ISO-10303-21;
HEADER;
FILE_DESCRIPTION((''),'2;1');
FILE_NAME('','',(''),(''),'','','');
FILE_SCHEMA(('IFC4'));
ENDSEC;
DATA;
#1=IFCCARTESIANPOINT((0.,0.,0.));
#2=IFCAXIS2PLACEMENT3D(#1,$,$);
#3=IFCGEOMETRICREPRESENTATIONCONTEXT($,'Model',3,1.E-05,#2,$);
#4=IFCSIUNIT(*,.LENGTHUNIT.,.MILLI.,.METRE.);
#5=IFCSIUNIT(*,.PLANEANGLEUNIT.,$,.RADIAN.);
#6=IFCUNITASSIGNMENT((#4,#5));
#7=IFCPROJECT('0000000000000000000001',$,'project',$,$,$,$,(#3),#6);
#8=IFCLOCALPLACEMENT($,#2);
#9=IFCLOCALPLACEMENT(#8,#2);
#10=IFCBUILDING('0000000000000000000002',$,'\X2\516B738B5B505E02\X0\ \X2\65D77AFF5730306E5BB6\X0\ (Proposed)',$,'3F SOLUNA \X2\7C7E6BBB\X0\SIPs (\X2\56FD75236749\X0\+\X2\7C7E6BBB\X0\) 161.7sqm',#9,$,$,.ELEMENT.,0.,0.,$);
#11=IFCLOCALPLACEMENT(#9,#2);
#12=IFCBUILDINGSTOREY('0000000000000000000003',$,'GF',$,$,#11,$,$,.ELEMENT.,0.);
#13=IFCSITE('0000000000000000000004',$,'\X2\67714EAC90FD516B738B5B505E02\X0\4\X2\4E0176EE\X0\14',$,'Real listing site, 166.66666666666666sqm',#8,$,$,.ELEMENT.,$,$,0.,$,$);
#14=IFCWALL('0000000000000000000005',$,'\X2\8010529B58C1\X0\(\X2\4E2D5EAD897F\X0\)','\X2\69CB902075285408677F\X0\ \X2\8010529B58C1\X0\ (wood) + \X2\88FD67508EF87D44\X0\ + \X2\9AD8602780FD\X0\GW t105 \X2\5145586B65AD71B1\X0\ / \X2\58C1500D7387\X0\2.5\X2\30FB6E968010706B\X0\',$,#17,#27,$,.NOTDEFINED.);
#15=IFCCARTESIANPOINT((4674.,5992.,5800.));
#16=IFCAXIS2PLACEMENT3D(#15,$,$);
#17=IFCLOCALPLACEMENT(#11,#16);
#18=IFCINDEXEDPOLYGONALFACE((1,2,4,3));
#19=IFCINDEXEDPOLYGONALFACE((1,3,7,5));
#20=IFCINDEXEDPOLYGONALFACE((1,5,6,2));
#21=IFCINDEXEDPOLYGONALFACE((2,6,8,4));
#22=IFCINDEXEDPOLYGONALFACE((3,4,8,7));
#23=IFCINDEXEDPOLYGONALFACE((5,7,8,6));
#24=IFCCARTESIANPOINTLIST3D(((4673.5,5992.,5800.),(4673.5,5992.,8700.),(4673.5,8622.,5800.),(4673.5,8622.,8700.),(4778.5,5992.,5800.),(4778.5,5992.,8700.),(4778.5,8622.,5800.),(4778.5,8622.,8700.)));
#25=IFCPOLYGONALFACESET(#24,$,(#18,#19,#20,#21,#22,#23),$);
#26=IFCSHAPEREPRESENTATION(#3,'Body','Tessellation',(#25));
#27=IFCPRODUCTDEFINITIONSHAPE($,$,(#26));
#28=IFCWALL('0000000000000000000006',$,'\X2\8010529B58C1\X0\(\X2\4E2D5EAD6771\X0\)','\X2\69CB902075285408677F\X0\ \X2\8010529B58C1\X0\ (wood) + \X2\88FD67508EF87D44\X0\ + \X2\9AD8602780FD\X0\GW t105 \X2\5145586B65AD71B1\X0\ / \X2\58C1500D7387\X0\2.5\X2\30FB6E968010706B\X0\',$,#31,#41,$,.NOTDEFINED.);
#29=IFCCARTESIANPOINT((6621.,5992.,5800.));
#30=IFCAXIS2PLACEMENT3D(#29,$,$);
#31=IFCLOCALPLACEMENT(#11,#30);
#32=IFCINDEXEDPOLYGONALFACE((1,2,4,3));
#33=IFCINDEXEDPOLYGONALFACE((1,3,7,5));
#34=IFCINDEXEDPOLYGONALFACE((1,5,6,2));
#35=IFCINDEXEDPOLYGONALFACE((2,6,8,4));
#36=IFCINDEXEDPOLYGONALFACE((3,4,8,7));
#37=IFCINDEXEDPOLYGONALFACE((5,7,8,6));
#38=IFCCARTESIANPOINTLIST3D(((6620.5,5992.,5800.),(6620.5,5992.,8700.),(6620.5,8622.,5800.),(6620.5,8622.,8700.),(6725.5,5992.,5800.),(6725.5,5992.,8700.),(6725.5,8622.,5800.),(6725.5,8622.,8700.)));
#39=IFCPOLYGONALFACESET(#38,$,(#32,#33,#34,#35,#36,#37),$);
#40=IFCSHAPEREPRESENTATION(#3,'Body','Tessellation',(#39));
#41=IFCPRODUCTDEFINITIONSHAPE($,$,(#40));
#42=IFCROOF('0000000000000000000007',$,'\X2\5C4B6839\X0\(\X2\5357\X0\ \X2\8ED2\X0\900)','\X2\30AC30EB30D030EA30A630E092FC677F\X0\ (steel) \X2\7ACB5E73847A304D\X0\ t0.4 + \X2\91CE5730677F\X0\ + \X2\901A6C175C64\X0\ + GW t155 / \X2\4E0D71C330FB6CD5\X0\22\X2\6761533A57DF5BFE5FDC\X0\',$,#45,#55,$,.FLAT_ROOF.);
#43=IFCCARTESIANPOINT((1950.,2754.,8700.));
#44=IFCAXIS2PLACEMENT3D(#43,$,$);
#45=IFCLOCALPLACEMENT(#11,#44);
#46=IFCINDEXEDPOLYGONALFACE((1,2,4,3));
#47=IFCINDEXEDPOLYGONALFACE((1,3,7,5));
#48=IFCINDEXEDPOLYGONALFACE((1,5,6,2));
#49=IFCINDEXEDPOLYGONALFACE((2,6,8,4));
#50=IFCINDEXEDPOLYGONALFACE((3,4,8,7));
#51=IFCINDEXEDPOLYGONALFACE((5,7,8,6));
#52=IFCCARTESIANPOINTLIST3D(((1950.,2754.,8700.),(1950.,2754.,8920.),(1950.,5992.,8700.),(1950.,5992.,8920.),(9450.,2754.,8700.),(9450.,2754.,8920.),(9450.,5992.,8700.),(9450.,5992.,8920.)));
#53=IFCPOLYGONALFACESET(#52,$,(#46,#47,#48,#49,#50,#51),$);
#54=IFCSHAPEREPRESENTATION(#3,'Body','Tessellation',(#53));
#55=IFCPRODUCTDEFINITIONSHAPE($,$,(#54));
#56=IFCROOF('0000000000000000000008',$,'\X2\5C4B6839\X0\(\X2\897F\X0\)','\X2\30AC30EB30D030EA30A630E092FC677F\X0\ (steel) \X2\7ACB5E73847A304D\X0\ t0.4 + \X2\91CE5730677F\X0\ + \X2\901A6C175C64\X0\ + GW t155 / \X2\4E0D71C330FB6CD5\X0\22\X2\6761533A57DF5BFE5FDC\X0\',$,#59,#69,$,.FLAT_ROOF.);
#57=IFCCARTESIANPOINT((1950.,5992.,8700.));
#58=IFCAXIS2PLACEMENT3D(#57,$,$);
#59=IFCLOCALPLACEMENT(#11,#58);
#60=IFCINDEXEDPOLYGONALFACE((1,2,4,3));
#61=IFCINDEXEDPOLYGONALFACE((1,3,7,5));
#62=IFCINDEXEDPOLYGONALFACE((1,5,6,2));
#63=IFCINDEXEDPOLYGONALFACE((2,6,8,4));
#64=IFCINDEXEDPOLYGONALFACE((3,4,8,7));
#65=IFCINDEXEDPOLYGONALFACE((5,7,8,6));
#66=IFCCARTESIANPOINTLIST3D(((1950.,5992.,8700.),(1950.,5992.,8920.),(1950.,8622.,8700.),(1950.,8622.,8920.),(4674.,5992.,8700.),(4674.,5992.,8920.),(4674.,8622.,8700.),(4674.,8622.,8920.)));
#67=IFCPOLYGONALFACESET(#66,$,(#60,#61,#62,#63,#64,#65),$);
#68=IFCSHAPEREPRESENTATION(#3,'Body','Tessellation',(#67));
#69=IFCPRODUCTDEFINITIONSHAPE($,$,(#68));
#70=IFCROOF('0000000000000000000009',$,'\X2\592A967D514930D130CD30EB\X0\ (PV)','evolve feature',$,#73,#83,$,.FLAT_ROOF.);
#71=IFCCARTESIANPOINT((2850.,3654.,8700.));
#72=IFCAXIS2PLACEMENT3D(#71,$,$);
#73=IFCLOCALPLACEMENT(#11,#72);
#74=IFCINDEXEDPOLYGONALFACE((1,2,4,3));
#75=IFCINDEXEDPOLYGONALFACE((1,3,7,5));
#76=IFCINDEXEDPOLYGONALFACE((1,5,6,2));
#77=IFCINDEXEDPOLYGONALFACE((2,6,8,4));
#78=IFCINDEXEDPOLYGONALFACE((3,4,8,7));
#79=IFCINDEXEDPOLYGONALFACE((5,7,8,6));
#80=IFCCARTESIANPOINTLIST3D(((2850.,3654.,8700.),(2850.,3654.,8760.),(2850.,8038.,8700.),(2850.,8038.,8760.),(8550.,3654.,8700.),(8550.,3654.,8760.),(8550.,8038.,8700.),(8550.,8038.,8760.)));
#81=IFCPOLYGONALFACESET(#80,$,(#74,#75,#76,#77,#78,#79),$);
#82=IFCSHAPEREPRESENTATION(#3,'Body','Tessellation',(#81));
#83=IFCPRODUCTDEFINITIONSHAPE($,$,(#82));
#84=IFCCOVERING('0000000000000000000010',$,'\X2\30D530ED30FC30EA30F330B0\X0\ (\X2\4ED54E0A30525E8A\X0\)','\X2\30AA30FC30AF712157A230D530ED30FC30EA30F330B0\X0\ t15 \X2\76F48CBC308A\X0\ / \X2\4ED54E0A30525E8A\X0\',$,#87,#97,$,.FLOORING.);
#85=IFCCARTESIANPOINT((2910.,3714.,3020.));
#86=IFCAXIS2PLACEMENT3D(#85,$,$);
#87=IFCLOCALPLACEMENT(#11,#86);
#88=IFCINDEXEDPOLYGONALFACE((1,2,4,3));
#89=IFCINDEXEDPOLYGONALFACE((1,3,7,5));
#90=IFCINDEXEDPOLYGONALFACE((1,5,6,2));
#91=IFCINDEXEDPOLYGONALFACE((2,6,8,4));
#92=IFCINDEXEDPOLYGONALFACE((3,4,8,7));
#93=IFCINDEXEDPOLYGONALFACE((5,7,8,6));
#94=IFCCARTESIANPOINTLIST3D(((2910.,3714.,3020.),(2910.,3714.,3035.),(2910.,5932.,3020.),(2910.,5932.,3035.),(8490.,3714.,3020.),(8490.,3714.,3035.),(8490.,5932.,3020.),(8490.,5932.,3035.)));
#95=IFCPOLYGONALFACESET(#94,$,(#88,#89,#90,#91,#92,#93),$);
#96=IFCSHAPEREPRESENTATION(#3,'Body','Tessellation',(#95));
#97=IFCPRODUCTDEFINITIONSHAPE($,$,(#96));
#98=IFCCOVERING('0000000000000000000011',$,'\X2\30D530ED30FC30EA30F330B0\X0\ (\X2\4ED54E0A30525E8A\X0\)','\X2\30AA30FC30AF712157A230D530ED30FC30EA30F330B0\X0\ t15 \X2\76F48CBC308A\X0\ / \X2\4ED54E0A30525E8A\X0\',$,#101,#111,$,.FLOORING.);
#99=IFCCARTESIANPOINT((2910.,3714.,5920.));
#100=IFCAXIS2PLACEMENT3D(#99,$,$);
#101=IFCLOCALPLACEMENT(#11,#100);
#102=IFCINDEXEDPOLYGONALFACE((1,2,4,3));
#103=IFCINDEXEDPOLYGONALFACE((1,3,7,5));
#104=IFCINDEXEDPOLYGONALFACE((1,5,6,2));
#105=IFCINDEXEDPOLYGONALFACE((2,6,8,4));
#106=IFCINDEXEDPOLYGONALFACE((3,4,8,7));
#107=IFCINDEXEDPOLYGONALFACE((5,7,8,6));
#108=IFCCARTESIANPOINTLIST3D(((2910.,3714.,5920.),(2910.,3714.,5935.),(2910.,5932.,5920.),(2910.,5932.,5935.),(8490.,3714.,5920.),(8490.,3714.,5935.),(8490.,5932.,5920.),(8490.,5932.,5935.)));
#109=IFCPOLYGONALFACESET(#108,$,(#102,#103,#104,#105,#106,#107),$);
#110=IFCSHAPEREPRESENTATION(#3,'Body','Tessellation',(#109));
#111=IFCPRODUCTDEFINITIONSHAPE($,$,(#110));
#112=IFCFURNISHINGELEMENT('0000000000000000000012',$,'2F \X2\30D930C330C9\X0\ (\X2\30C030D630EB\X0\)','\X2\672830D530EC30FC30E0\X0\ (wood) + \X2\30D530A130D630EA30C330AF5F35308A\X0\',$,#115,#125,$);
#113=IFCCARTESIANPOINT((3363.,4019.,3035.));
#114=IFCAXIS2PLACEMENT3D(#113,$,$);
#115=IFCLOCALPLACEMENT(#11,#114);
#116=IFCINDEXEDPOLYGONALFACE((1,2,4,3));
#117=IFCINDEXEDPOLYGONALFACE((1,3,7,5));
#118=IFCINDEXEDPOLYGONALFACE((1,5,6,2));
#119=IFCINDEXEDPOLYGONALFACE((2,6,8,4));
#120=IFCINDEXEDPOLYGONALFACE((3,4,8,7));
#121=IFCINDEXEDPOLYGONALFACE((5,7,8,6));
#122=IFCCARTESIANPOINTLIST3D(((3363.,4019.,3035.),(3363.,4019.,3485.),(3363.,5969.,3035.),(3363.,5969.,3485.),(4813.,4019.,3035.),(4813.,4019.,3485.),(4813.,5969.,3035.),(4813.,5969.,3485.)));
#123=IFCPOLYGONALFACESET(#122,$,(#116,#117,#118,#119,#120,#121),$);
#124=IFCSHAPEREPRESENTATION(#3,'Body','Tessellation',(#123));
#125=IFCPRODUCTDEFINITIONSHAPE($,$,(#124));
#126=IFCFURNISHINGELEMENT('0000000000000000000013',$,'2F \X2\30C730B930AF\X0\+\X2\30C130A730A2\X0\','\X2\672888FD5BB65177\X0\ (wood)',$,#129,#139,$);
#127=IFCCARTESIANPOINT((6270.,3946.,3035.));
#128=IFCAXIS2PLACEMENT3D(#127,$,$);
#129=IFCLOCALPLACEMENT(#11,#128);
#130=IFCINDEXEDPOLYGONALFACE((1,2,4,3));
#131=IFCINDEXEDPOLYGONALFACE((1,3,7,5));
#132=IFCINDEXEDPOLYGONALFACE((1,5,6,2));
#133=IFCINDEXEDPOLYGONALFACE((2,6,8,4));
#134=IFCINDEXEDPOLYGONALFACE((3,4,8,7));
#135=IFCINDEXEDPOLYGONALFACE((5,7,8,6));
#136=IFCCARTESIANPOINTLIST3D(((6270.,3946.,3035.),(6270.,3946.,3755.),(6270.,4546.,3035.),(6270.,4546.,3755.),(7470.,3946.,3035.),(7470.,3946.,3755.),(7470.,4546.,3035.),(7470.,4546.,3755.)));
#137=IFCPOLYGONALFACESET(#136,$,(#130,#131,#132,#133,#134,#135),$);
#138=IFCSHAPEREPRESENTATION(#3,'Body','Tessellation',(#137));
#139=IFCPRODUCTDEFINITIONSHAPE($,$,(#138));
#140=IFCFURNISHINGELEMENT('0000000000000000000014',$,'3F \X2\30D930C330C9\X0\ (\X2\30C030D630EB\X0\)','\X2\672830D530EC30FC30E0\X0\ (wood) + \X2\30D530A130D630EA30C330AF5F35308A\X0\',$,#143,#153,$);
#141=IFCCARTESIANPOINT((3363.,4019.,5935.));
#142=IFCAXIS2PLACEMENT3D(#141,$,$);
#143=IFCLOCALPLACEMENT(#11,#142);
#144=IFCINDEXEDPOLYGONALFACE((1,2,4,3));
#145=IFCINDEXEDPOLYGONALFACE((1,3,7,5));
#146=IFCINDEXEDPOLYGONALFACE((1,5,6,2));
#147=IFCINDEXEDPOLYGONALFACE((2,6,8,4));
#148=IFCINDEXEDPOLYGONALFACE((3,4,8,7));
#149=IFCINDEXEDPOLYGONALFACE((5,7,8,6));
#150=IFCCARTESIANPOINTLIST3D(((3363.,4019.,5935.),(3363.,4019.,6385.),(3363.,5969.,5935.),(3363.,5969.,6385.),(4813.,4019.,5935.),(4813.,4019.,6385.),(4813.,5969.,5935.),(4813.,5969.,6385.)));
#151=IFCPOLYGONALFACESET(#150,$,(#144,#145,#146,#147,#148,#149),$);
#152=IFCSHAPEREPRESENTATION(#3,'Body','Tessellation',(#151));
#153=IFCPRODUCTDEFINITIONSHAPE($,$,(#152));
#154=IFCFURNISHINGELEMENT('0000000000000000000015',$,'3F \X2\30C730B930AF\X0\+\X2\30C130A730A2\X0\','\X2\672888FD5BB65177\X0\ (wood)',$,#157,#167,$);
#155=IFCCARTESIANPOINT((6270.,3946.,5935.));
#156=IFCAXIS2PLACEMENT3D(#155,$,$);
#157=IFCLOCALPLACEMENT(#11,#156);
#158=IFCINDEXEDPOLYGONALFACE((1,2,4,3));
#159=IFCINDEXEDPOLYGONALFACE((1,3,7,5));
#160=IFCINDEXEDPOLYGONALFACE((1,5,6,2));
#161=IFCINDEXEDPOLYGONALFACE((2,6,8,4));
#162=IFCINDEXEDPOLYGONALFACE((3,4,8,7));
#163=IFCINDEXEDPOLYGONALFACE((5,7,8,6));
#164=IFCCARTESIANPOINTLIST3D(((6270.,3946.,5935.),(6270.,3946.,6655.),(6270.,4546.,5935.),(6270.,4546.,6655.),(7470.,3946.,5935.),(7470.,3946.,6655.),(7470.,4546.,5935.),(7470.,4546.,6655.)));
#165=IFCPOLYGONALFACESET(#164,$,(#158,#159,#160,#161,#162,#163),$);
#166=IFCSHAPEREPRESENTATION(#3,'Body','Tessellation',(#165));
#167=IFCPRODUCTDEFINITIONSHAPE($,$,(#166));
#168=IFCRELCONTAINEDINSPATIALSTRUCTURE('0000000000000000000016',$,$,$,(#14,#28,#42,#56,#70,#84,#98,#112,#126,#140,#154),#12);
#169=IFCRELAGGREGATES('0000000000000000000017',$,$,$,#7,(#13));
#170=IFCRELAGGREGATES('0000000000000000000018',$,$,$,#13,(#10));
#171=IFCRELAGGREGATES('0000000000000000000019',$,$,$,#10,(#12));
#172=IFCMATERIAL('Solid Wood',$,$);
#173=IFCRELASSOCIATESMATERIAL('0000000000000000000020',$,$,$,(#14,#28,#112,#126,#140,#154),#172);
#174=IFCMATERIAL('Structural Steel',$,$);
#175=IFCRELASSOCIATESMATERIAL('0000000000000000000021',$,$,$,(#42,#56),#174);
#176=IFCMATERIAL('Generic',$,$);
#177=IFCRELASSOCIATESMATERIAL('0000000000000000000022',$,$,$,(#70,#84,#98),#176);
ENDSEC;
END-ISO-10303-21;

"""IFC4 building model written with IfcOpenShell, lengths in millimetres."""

from ifc_helpers import new_model, si_unit, frame, frame_2d, origin, place, context, project, spatial, rectangle, extrude, material, element, save


model = new_model("IFC4")

# Units and contexts
model_context = context("Model", 3, precision=1e-05, world=origin())
ifc_project = project(units=[si_unit("LENGTHUNIT", "METRE", prefix="MILLI"), si_unit("PLANEANGLEUNIT", "RADIAN")], contexts=[model_context])

# Site, building, storey
site_placement = place(None, origin())
site = spatial("IfcSite", under=ifc_project, at=site_placement, Name="東京都八王子市4丁目14", ObjectType="Real listing site, 166.66666666666666sqm", CompositionType="ELEMENT", RefElevation=0.0)
building_placement = place(site_placement, origin())
building = spatial("IfcBuilding", under=site, at=building_placement, Name="八王子市 旗竿地の家 (Proposed)", ObjectType="3F SOLUNA 籾殻SIPs (国産杉+籾殻) 161.7sqm", CompositionType="ELEMENT", ElevationOfRefHeight=0.0, ElevationOfTerrain=0.0)
storey_placement = place(building_placement, origin())
storey = spatial("IfcBuildingStorey", under=building, at=storey_placement, Name="GF", CompositionType="ELEMENT", Elevation=0.0)

# Shared definitions
ifc_material_1 = material(Name="Solid Wood")

# Walls
wall_1_placement = place(storey_placement, frame((4674.0, 5992.0, 5800.0)))
element("IfcWall", 1, at=wall_1_placement, inside=storey, material=ifc_material_1, Name="耐力壁(中庭西)", Description="構造用合板 耐力壁 (wood) + 製材軸組 + 高性能GW t105 充填断熱 / 壁倍率2.5・準耐火", PredefinedType="NOTDEFINED", context=model_context, shape_type="SweptSolid", body=[
    extrude(rectangle(XDim=105.0, YDim=2630.0, at=frame_2d((52.0, 1315.0))), frame((4674.0, 5992.0, 5800.0)), (0.0, 0.0, 1.0), 2900.0),
])
wall_2_placement = place(storey_placement, frame((6621.0, 5992.0, 5800.0)))
element("IfcWall", 2, at=wall_2_placement, inside=storey, material=ifc_material_1, Name="耐力壁(中庭東)", Description="構造用合板 耐力壁 (wood) + 製材軸組 + 高性能GW t105 充填断熱 / 壁倍率2.5・準耐火", PredefinedType="NOTDEFINED", context=model_context, shape_type="SweptSolid", body=[
    extrude(rectangle(XDim=105.0, YDim=2630.0, at=frame_2d((52.0, 1315.0))), frame((6621.0, 5992.0, 5800.0)), (0.0, 0.0, 1.0), 2900.0),
])

# Roofs
ifc_material_2 = material(Name="Structural Steel")
roof_1_placement = place(storey_placement, frame((1950.0, 2754.0, 8700.0)))
element("IfcRoof", 3, at=roof_1_placement, inside=storey, material=ifc_material_2, Name="屋根(南 軒900)", Description="ガルバリウム鋼板 (steel) 立平葺き t0.4 + 野地板 + 通気層 + GW t155 / 不燃・法22条区域対応", PredefinedType="FLAT_ROOF", context=model_context, shape_type="SweptSolid", body=[
    extrude(rectangle(XDim=7500.0, YDim=3238.0, at=frame_2d((3750.0, 1619.0))), frame((1950.0, 2754.0, 8700.0)), (0.0, 0.0, 1.0), 220.0),
])
roof_2_placement = place(storey_placement, frame((1950.0, 5992.0, 8700.0)))
element("IfcRoof", 4, at=roof_2_placement, inside=storey, material=ifc_material_2, Name="屋根(西)", Description="ガルバリウム鋼板 (steel) 立平葺き t0.4 + 野地板 + 通気層 + GW t155 / 不燃・法22条区域対応", PredefinedType="FLAT_ROOF", context=model_context, shape_type="SweptSolid", body=[
    extrude(rectangle(XDim=2724.0, YDim=2630.0, at=frame_2d((1362.0, 1315.0))), frame((1950.0, 5992.0, 8700.0)), (0.0, 0.0, 1.0), 220.0),
])
ifc_material_3 = material(Name="Generic")
roof_3_placement = place(storey_placement, frame((2850.0, 3654.0, 8700.0)))
element("IfcRoof", 5, at=roof_3_placement, inside=storey, material=ifc_material_3, Name="太陽光パネル (PV)", Description="evolve feature", PredefinedType="FLAT_ROOF", context=model_context, shape_type="SweptSolid", body=[
    extrude(rectangle(XDim=5700.0, YDim=4384.0, at=frame_2d((2850.0, 2192.0))), frame((2850.0, 3654.0, 8700.0)), (0.0, 0.0, 1.0), 60.0),
])

# Coverings
covering_1_placement = place(storey_placement, frame((2910.0, 3714.0, 3020.0)))
element("IfcCovering", 6, at=covering_1_placement, inside=storey, material=ifc_material_3, Name="フローリング (仕上げ床)", Description="オーク無垢フローリング t15 直貼り / 仕上げ床", PredefinedType="FLOORING", context=model_context, shape_type="SweptSolid", body=[
    extrude(rectangle(XDim=5580.0, YDim=2218.0, at=frame_2d((2790.0, 1109.0))), frame((2910.0, 3714.0, 3020.0)), (0.0, 0.0, 1.0), 15.0),
])
covering_2_placement = place(storey_placement, frame((2910.0, 3714.0, 5920.0)))
element("IfcCovering", 7, at=covering_2_placement, inside=storey, material=ifc_material_3, Name="フローリング (仕上げ床)", Description="オーク無垢フローリング t15 直貼り / 仕上げ床", PredefinedType="FLOORING", context=model_context, shape_type="SweptSolid", body=[
    extrude(rectangle(XDim=5580.0, YDim=2218.0, at=frame_2d((2790.0, 1109.0))), frame((2910.0, 3714.0, 5920.0)), (0.0, 0.0, 1.0), 15.0),
])

# Furnishing elements
furnishing_1_placement = place(storey_placement, frame((3363.0, 4019.0, 3035.0)))
element("IfcFurnishingElement", 8, at=furnishing_1_placement, inside=storey, material=ifc_material_1, Name="2F ベッド (ダブル)", Description="木フレーム (wood) + ファブリック張り", context=model_context, shape_type="SweptSolid", body=[
    extrude(rectangle(XDim=1450.0, YDim=1950.0, at=frame_2d((725.0, 975.0))), frame((3363.0, 4019.0, 3035.0)), (0.0, 0.0, 1.0), 450.0),
])
furnishing_2_placement = place(storey_placement, frame((6270.0, 3946.0, 3035.0)))
element("IfcFurnishingElement", 9, at=furnishing_2_placement, inside=storey, material=ifc_material_1, Name="2F デスク+チェア", Description="木製家具 (wood)", context=model_context, shape_type="SweptSolid", body=[
    extrude(rectangle(XDim=1200.0, YDim=600.0, at=frame_2d((600.0, 300.0))), frame((6270.0, 3946.0, 3035.0)), (0.0, 0.0, 1.0), 720.0),
])
furnishing_3_placement = place(storey_placement, frame((3363.0, 4019.0, 5935.0)))
element("IfcFurnishingElement", 10, at=furnishing_3_placement, inside=storey, material=ifc_material_1, Name="3F ベッド (ダブル)", Description="木フレーム (wood) + ファブリック張り", context=model_context, shape_type="SweptSolid", body=[
    extrude(rectangle(XDim=1450.0, YDim=1950.0, at=frame_2d((725.0, 975.0))), frame((3363.0, 4019.0, 5935.0)), (0.0, 0.0, 1.0), 450.0),
])
furnishing_4_placement = place(storey_placement, frame((6270.0, 3946.0, 5935.0)))
element("IfcFurnishingElement", 11, at=furnishing_4_placement, inside=storey, material=ifc_material_1, Name="3F デスク+チェア", Description="木製家具 (wood)", context=model_context, shape_type="SweptSolid", body=[
    extrude(rectangle(XDim=1200.0, YDim=600.0, at=frame_2d((600.0, 300.0))), frame((6270.0, 3946.0, 5935.0)), (0.0, 0.0, 1.0), 720.0),
])

save(model, "model.ifc")
